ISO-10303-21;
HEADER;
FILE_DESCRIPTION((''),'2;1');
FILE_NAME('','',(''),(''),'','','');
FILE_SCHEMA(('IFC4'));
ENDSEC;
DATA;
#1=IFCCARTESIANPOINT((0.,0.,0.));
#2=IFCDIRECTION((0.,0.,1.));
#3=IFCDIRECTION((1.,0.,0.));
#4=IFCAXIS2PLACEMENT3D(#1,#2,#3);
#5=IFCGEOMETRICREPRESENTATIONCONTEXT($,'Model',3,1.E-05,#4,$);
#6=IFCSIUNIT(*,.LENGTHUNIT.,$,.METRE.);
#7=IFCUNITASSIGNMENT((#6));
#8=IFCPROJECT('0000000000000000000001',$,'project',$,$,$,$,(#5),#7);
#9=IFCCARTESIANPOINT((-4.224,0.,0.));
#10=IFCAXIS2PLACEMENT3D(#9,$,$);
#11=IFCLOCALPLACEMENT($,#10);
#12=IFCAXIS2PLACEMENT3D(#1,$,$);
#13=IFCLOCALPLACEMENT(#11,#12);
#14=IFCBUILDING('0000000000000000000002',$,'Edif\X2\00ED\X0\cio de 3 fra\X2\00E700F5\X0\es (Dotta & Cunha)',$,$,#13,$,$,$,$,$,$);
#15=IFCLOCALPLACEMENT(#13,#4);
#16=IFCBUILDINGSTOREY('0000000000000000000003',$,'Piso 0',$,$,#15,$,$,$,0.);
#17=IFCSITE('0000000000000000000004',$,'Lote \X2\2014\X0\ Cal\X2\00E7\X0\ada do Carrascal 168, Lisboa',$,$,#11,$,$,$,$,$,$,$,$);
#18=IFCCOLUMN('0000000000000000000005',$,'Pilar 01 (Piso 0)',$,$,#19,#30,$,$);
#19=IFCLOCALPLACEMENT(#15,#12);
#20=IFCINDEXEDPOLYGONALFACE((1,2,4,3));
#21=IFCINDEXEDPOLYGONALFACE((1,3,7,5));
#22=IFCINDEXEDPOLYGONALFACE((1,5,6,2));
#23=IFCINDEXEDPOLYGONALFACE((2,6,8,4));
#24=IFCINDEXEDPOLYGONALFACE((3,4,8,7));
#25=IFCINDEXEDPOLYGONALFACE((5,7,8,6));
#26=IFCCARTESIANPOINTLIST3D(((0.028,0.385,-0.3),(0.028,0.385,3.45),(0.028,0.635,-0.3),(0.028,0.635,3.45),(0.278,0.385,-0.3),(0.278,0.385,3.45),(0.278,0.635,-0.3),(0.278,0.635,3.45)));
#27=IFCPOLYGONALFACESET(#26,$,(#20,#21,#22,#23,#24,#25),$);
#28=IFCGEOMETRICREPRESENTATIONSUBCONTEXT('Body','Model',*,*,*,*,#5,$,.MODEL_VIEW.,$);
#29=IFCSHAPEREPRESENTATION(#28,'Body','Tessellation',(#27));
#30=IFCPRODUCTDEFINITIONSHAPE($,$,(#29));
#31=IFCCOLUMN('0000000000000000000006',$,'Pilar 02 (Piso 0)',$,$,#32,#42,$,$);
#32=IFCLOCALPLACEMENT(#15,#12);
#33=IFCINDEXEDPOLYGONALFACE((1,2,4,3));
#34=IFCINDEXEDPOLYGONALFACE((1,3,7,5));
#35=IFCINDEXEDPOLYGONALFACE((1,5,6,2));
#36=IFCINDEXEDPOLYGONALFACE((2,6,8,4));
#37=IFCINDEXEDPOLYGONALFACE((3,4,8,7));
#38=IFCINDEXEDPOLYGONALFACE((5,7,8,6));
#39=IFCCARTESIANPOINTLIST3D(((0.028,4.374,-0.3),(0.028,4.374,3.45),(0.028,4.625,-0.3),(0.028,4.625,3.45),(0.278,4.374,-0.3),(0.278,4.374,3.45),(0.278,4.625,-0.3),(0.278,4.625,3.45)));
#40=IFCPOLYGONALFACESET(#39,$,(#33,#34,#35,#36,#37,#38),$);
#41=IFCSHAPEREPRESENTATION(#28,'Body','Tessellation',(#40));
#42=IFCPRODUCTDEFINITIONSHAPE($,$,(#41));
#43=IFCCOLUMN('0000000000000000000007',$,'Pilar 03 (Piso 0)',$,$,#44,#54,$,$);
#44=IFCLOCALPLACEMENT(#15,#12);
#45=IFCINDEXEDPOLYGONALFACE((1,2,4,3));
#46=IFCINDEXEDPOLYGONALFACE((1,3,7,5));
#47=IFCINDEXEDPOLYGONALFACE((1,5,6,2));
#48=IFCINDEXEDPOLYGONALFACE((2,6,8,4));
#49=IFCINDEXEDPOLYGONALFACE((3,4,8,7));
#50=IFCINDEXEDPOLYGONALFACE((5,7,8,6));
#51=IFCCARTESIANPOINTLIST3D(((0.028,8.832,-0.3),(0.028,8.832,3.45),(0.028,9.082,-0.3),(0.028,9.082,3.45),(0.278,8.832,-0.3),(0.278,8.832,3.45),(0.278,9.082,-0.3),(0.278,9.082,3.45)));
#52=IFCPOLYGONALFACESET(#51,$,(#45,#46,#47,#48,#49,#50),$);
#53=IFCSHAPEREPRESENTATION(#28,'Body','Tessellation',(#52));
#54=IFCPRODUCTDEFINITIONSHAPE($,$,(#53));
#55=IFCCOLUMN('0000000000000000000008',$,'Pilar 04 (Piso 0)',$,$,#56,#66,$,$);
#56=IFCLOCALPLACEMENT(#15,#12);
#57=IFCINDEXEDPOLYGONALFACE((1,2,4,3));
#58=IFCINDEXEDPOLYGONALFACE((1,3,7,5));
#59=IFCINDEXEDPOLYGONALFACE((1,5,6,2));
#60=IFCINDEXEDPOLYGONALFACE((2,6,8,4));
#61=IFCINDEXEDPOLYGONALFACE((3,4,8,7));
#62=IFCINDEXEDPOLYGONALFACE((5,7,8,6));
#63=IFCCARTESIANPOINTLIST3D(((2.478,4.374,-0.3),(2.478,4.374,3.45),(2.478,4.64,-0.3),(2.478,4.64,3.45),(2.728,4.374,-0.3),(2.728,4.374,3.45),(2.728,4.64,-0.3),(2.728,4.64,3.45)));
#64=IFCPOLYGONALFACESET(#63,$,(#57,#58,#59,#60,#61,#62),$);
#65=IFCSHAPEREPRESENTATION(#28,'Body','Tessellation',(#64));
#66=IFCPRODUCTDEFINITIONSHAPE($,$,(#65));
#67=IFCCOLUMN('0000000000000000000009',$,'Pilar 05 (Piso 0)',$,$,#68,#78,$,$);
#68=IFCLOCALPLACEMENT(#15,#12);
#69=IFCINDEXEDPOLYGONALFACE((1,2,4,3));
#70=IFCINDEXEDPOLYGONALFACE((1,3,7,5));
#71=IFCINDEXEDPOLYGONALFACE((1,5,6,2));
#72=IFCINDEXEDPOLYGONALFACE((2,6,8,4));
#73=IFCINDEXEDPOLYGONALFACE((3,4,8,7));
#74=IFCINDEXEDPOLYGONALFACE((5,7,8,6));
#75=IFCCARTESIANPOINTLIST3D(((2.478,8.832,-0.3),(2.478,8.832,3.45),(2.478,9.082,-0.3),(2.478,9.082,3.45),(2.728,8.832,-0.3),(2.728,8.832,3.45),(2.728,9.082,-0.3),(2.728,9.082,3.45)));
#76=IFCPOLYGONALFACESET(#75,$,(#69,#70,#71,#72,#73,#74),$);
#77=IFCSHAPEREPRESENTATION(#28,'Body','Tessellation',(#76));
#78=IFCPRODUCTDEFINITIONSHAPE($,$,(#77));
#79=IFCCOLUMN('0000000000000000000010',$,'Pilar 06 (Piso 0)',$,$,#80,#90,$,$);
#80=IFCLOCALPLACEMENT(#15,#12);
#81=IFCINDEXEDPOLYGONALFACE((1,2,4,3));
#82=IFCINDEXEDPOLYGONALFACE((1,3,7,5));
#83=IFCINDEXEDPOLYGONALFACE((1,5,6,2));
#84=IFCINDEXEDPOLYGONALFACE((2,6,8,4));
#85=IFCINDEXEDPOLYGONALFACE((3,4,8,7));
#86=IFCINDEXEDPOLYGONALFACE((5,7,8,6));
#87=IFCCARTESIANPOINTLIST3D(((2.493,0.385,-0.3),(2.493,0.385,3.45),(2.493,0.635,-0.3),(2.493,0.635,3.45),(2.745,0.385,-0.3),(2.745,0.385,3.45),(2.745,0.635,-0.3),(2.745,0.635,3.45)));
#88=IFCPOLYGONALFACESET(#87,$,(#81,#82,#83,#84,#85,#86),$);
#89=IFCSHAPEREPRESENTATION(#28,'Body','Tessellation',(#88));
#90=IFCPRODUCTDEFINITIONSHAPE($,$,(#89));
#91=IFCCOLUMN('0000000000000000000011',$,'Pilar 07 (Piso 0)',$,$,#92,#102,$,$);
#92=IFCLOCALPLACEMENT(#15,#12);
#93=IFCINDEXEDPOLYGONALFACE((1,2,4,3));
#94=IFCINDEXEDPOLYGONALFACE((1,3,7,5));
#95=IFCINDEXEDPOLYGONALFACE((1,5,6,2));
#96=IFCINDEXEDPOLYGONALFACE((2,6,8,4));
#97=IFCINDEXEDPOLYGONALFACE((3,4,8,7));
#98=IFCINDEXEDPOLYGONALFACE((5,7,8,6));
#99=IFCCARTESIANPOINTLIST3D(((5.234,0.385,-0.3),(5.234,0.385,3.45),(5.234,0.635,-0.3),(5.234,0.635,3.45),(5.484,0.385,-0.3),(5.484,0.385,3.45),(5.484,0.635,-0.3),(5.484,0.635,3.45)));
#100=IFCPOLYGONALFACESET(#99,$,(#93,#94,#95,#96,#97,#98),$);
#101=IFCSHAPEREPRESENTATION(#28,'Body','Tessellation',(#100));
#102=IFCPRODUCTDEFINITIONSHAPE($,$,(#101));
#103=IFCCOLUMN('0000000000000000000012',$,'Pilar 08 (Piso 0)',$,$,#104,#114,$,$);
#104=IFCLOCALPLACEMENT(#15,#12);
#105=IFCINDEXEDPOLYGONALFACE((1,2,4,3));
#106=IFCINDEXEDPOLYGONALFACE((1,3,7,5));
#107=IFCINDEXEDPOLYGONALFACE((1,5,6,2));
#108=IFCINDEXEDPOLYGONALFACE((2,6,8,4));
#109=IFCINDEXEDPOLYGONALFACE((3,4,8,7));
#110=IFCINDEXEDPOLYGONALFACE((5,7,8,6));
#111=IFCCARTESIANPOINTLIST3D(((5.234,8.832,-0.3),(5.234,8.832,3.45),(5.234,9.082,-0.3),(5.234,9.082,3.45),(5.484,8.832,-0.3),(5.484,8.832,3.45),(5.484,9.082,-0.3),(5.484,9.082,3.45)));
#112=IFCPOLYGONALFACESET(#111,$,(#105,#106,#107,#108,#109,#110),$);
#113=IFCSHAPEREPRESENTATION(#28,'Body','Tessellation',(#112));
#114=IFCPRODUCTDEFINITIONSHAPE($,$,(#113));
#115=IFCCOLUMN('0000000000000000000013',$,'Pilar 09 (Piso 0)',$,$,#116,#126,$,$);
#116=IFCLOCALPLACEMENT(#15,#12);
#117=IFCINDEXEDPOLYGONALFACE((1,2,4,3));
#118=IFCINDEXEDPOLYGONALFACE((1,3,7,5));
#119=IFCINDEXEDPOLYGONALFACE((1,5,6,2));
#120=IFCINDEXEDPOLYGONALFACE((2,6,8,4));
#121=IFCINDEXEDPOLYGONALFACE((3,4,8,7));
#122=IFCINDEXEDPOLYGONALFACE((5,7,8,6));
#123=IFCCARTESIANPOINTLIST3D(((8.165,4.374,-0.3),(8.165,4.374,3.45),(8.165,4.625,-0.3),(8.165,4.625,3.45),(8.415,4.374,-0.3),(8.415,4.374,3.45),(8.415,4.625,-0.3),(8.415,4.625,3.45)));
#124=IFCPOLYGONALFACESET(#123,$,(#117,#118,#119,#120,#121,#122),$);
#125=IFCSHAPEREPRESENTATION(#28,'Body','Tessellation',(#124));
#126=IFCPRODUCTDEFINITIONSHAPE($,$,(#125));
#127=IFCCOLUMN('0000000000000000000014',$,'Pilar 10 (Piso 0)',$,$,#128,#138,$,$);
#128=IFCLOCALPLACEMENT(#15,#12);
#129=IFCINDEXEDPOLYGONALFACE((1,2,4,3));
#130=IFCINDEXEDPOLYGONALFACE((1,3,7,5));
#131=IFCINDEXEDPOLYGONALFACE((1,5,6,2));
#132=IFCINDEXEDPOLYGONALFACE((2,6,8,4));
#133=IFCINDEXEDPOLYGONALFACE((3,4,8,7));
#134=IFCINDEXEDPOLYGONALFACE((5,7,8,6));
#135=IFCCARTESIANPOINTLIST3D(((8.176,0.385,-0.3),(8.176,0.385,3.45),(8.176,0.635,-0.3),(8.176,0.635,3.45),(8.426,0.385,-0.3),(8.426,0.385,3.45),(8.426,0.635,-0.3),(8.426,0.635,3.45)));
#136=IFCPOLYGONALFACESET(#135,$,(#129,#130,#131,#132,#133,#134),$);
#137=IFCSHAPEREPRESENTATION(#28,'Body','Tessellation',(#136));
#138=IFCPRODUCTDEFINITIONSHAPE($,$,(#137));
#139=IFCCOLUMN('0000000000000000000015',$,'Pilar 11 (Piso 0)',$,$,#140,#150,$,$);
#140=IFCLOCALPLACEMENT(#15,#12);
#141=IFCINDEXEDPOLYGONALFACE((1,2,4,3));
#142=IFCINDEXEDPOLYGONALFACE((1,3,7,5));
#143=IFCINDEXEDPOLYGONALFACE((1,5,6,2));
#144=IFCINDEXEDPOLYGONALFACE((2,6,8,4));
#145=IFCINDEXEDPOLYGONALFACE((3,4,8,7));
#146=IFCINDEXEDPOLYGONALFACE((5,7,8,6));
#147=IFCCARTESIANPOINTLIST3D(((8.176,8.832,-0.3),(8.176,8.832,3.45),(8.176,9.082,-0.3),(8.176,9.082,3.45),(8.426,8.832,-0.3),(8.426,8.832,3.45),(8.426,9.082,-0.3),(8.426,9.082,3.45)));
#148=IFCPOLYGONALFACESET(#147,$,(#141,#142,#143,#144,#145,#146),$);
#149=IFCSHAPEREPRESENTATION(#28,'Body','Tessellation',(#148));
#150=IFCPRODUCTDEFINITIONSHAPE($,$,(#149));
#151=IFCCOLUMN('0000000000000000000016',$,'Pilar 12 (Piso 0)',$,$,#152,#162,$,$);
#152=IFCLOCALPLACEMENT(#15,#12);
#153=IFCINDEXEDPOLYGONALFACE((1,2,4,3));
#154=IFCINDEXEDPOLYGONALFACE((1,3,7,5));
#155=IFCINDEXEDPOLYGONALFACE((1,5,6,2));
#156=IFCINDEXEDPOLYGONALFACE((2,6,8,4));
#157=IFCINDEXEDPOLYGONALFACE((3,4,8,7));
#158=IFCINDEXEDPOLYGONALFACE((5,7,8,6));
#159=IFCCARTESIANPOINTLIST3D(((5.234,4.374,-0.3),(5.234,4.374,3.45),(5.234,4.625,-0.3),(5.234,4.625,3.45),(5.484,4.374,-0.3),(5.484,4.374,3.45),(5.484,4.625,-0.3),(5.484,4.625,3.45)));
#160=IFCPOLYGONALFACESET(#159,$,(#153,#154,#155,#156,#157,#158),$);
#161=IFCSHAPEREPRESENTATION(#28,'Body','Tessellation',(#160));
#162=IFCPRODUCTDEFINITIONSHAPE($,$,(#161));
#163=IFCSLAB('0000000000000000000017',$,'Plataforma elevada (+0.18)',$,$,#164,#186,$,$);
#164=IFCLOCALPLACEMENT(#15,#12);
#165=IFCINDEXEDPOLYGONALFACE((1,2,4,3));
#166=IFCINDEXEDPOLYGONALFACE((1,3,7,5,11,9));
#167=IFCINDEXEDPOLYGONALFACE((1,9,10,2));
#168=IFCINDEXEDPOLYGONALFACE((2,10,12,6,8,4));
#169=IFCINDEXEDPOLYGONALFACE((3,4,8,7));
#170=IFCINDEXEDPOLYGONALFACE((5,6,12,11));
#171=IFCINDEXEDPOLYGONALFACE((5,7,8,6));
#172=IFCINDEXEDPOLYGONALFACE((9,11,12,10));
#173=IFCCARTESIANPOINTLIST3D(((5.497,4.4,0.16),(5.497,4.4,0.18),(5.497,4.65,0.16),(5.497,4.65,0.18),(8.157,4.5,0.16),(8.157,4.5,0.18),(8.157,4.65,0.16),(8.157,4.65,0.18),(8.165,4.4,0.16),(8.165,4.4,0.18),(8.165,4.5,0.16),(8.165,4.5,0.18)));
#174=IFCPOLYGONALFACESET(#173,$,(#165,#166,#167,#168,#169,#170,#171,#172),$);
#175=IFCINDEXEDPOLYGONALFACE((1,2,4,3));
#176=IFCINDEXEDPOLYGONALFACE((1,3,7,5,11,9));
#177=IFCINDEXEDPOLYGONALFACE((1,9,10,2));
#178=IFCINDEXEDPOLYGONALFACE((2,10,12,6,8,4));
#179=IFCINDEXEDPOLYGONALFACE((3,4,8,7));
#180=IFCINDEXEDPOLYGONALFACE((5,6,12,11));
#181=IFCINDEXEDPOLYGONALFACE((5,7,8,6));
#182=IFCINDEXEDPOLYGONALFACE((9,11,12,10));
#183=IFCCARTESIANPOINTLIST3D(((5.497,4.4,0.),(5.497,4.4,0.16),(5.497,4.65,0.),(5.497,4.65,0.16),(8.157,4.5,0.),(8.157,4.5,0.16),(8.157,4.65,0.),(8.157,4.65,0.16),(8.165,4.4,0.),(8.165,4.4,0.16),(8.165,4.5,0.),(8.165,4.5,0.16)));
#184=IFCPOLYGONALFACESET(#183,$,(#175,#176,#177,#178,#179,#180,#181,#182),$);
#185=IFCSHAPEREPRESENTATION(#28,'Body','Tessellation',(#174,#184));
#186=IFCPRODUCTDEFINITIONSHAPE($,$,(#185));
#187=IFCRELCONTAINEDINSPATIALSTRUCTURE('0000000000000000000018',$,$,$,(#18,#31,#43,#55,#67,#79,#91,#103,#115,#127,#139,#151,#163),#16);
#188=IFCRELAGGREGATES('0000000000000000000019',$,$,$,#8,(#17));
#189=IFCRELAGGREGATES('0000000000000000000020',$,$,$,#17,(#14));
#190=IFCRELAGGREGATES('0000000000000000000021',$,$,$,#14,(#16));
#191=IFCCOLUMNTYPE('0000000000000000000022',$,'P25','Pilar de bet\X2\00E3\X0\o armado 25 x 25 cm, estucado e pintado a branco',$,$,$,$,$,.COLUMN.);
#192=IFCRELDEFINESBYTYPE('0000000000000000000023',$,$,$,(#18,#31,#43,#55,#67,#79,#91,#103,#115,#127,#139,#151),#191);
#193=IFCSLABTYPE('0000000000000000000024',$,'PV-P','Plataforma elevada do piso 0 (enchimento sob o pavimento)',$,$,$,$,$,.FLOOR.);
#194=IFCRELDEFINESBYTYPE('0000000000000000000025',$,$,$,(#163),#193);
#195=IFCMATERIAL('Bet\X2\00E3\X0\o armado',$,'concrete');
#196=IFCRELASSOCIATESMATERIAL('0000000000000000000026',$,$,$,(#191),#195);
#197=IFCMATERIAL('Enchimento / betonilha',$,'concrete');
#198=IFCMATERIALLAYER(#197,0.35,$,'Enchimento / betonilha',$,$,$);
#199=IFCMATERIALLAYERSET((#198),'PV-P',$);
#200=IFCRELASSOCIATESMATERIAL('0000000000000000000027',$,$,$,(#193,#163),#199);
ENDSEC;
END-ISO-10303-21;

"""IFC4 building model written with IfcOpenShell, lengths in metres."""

from ifc_helpers import new_model, si_unit, frame, origin, origin_with_axes, place, context, subcontext, project, spatial, line, indexed_curve, outline, extrude, material, layer, layer_set, layer_usage, type_object, element, save


model = new_model("IFC4")

# Units and contexts
model_context = context("Model", 3, precision=1e-05, world=origin_with_axes())
body_context = subcontext(model_context, "Body", "Model", "MODEL_VIEW")
ifc_project = project(units=[si_unit("LENGTHUNIT", "METRE")], contexts=[model_context])

# Site, building, storey
site_placement = place(None, frame((-4.224, 0.0, 0.0)))
site = spatial("IfcSite", under=ifc_project, at=site_placement, Name="Lote — Calçada do Carrascal 168, Lisboa")
building_placement = place(site_placement, origin())
building = spatial("IfcBuilding", under=site, at=building_placement, Name="Edifício de 3 frações (Dotta & Cunha)")
storey_placement = place(building_placement, origin_with_axes())
storey = spatial("IfcBuildingStorey", under=building, at=storey_placement, Name="Piso 0", Elevation=0.0)

# Columns
ifc_material_1 = material(Name="Betão armado", Category="concrete")
column_type = type_object("IfcColumnType", Name="P25", Description="Pilar de betão armado 25 x 25 cm, estucado e pintado a branco", PredefinedType="COLUMN", material=ifc_material_1)
column_1_placement = place(storey_placement, frame((0.0, 0.0, -0.3), z_axis=(0.0, 0.0, 1.0), x_axis=(1.0, 0.0, 0.0)))
element("IfcColumn", 1, at=column_1_placement, inside=storey, type_object=column_type, Name="Pilar 01 (Piso 0)", context=body_context, shape_type="SweptSolid", body=[
    extrude(outline(indexed_curve([(0.278, 0.385), (0.028, 0.385), (0.028, 0.635), (0.278, 0.635)], segments=[line(1, 2, 3, 4, 1)])), origin_with_axes(), (0.0, 0.0, 1.0), 3.75),
])
column_2_placement = place(storey_placement, frame((0.0, 0.0, -0.3), z_axis=(0.0, 0.0, 1.0), x_axis=(1.0, 0.0, 0.0)))
element("IfcColumn", 2, at=column_2_placement, inside=storey, type_object=column_type, Name="Pilar 02 (Piso 0)", context=body_context, shape_type="SweptSolid", body=[
    extrude(outline(indexed_curve([(0.278, 4.374), (0.028, 4.374), (0.028, 4.625), (0.278, 4.625)], segments=[line(1, 2, 3, 4, 1)])), origin_with_axes(), (0.0, 0.0, 1.0), 3.75),
])
column_3_placement = place(storey_placement, frame((0.0, 0.0, -0.3), z_axis=(0.0, 0.0, 1.0), x_axis=(1.0, 0.0, 0.0)))
element("IfcColumn", 3, at=column_3_placement, inside=storey, type_object=column_type, Name="Pilar 03 (Piso 0)", context=body_context, shape_type="SweptSolid", body=[
    extrude(outline(indexed_curve([(0.028, 9.082), (0.278, 9.082), (0.278, 8.832), (0.028, 8.832)], segments=[line(1, 2, 3, 4, 1)])), origin_with_axes(), (0.0, 0.0, 1.0), 3.75),
])
column_4_placement = place(storey_placement, frame((0.0, 0.0, -0.3), z_axis=(0.0, 0.0, 1.0), x_axis=(1.0, 0.0, 0.0)))
element("IfcColumn", 4, at=column_4_placement, inside=storey, type_object=column_type, Name="Pilar 04 (Piso 0)", context=body_context, shape_type="SweptSolid", body=[
    extrude(outline(indexed_curve([(2.478, 4.374), (2.478, 4.64), (2.728, 4.64), (2.728, 4.374)], segments=[line(1, 2, 3, 4, 1)])), origin_with_axes(), (0.0, 0.0, 1.0), 3.75),
])
column_5_placement = place(storey_placement, frame((0.0, 0.0, -0.3), z_axis=(0.0, 0.0, 1.0), x_axis=(1.0, 0.0, 0.0)))
element("IfcColumn", 5, at=column_5_placement, inside=storey, type_object=column_type, Name="Pilar 05 (Piso 0)", context=body_context, shape_type="SweptSolid", body=[
    extrude(outline(indexed_curve([(2.478, 9.082), (2.728, 9.082), (2.728, 8.832), (2.478, 8.832)], segments=[line(1, 2, 3, 4, 1)])), origin_with_axes(), (0.0, 0.0, 1.0), 3.75),
])
column_6_placement = place(storey_placement, frame((0.0, 0.0, -0.3), z_axis=(0.0, 0.0, 1.0), x_axis=(1.0, 0.0, 0.0)))
element("IfcColumn", 6, at=column_6_placement, inside=storey, type_object=column_type, Name="Pilar 06 (Piso 0)", context=body_context, shape_type="SweptSolid", body=[
    extrude(outline(indexed_curve([(2.493, 0.385), (2.493, 0.635), (2.745, 0.635), (2.745, 0.385)], segments=[line(1, 2, 3, 4, 1)])), origin_with_axes(), (0.0, 0.0, 1.0), 3.75),
])
column_7_placement = place(storey_placement, frame((0.0, 0.0, -0.3), z_axis=(0.0, 0.0, 1.0), x_axis=(1.0, 0.0, 0.0)))
element("IfcColumn", 7, at=column_7_placement, inside=storey, type_object=column_type, Name="Pilar 07 (Piso 0)", context=body_context, shape_type="SweptSolid", body=[
    extrude(outline(indexed_curve([(5.234, 0.385), (5.234, 0.635), (5.484, 0.635), (5.484, 0.385)], segments=[line(1, 2, 3, 4, 1)])), origin_with_axes(), (0.0, 0.0, 1.0), 3.75),
])
column_8_placement = place(storey_placement, frame((0.0, 0.0, -0.3), z_axis=(0.0, 0.0, 1.0), x_axis=(1.0, 0.0, 0.0)))
element("IfcColumn", 8, at=column_8_placement, inside=storey, type_object=column_type, Name="Pilar 08 (Piso 0)", context=body_context, shape_type="SweptSolid", body=[
    extrude(outline(indexed_curve([(5.234, 9.082), (5.484, 9.082), (5.484, 8.832), (5.234, 8.832)], segments=[line(1, 2, 3, 4, 1)])), origin_with_axes(), (0.0, 0.0, 1.0), 3.75),
])
column_9_placement = place(storey_placement, frame((0.0, 0.0, -0.3), z_axis=(0.0, 0.0, 1.0), x_axis=(1.0, 0.0, 0.0)))
element("IfcColumn", 9, at=column_9_placement, inside=storey, type_object=column_type, Name="Pilar 09 (Piso 0)", context=body_context, shape_type="SweptSolid", body=[
    extrude(outline(indexed_curve([(8.165, 4.625), (8.415, 4.625), (8.415, 4.374), (8.165, 4.374)], segments=[line(1, 2, 3, 4, 1)])), origin_with_axes(), (0.0, 0.0, 1.0), 3.75),
])
column_10_placement = place(storey_placement, frame((0.0, 0.0, -0.3), z_axis=(0.0, 0.0, 1.0), x_axis=(1.0, 0.0, 0.0)))
element("IfcColumn", 10, at=column_10_placement, inside=storey, type_object=column_type, Name="Pilar 10 (Piso 0)", context=body_context, shape_type="SweptSolid", body=[
    extrude(outline(indexed_curve([(8.176, 0.635), (8.426, 0.635), (8.426, 0.385), (8.176, 0.385)], segments=[line(1, 2, 3, 4, 1)])), origin_with_axes(), (0.0, 0.0, 1.0), 3.75),
])
column_11_placement = place(storey_placement, frame((0.0, 0.0, -0.3), z_axis=(0.0, 0.0, 1.0), x_axis=(1.0, 0.0, 0.0)))
element("IfcColumn", 11, at=column_11_placement, inside=storey, type_object=column_type, Name="Pilar 11 (Piso 0)", context=body_context, shape_type="SweptSolid", body=[
    extrude(outline(indexed_curve([(8.176, 9.082), (8.426, 9.082), (8.426, 8.832), (8.176, 8.832)], segments=[line(1, 2, 3, 4, 1)])), origin_with_axes(), (0.0, 0.0, 1.0), 3.75),
])
column_12_placement = place(storey_placement, frame((0.0, 0.0, -0.3), z_axis=(0.0, 0.0, 1.0), x_axis=(1.0, 0.0, 0.0)))
element("IfcColumn", 12, at=column_12_placement, inside=storey, type_object=column_type, Name="Pilar 12 (Piso 0)", context=body_context, shape_type="SweptSolid", body=[
    extrude(outline(indexed_curve([(5.234, 4.625), (5.484, 4.625), (5.484, 4.374), (5.234, 4.374)], segments=[line(1, 2, 3, 4, 1)])), origin_with_axes(), (0.0, 0.0, 1.0), 3.75),
])

# Slab
ifc_material_2 = material(Name="Enchimento / betonilha", Category="concrete")
ifc_layer_1 = layer(ifc_material_2, 0.35, Name="Enchimento / betonilha")
ifc_layer_set_1 = layer_set([ifc_layer_1], Name="PV-P")
ifc_layer_usage_1 = layer_usage(ifc_layer_set_1, "AXIS3", "POSITIVE", 0.0)
slab_type = type_object("IfcSlabType", Name="PV-P", Description="Plataforma elevada do piso 0 (enchimento sob o pavimento)", PredefinedType="FLOOR", material=ifc_layer_set_1)
slab_1_placement = place(storey_placement, origin_with_axes())
element("IfcSlab", 13, at=slab_1_placement, inside=storey, type_object=slab_type, material=ifc_layer_usage_1, Name="Plataforma elevada (+0.18)", context=body_context, shape_type="SweptSolid", body=[
    extrude(outline(indexed_curve([(8.165, 4.5), (8.165, 4.4), (5.497, 4.4), (5.497, 4.65), (8.157, 4.65), (8.157, 4.5)], segments=[line(1, 2, 3, 4, 5, 6, 1)])), frame((0.0, 0.0, 0.16), z_axis=(0.0, 0.0, 1.0), x_axis=(1.0, 0.0, 0.0)), (0.0, 0.0, 1.0), 0.02),
    extrude(outline(indexed_curve([(8.165, 4.5), (8.165, 4.4), (5.497, 4.4), (5.497, 4.65), (8.157, 4.65), (8.157, 4.5)], segments=[line(1, 2, 3, 4, 5, 6, 1)])), origin_with_axes(), (0.0, 0.0, 1.0), 0.16),
])

save(model, "model.ifc")
